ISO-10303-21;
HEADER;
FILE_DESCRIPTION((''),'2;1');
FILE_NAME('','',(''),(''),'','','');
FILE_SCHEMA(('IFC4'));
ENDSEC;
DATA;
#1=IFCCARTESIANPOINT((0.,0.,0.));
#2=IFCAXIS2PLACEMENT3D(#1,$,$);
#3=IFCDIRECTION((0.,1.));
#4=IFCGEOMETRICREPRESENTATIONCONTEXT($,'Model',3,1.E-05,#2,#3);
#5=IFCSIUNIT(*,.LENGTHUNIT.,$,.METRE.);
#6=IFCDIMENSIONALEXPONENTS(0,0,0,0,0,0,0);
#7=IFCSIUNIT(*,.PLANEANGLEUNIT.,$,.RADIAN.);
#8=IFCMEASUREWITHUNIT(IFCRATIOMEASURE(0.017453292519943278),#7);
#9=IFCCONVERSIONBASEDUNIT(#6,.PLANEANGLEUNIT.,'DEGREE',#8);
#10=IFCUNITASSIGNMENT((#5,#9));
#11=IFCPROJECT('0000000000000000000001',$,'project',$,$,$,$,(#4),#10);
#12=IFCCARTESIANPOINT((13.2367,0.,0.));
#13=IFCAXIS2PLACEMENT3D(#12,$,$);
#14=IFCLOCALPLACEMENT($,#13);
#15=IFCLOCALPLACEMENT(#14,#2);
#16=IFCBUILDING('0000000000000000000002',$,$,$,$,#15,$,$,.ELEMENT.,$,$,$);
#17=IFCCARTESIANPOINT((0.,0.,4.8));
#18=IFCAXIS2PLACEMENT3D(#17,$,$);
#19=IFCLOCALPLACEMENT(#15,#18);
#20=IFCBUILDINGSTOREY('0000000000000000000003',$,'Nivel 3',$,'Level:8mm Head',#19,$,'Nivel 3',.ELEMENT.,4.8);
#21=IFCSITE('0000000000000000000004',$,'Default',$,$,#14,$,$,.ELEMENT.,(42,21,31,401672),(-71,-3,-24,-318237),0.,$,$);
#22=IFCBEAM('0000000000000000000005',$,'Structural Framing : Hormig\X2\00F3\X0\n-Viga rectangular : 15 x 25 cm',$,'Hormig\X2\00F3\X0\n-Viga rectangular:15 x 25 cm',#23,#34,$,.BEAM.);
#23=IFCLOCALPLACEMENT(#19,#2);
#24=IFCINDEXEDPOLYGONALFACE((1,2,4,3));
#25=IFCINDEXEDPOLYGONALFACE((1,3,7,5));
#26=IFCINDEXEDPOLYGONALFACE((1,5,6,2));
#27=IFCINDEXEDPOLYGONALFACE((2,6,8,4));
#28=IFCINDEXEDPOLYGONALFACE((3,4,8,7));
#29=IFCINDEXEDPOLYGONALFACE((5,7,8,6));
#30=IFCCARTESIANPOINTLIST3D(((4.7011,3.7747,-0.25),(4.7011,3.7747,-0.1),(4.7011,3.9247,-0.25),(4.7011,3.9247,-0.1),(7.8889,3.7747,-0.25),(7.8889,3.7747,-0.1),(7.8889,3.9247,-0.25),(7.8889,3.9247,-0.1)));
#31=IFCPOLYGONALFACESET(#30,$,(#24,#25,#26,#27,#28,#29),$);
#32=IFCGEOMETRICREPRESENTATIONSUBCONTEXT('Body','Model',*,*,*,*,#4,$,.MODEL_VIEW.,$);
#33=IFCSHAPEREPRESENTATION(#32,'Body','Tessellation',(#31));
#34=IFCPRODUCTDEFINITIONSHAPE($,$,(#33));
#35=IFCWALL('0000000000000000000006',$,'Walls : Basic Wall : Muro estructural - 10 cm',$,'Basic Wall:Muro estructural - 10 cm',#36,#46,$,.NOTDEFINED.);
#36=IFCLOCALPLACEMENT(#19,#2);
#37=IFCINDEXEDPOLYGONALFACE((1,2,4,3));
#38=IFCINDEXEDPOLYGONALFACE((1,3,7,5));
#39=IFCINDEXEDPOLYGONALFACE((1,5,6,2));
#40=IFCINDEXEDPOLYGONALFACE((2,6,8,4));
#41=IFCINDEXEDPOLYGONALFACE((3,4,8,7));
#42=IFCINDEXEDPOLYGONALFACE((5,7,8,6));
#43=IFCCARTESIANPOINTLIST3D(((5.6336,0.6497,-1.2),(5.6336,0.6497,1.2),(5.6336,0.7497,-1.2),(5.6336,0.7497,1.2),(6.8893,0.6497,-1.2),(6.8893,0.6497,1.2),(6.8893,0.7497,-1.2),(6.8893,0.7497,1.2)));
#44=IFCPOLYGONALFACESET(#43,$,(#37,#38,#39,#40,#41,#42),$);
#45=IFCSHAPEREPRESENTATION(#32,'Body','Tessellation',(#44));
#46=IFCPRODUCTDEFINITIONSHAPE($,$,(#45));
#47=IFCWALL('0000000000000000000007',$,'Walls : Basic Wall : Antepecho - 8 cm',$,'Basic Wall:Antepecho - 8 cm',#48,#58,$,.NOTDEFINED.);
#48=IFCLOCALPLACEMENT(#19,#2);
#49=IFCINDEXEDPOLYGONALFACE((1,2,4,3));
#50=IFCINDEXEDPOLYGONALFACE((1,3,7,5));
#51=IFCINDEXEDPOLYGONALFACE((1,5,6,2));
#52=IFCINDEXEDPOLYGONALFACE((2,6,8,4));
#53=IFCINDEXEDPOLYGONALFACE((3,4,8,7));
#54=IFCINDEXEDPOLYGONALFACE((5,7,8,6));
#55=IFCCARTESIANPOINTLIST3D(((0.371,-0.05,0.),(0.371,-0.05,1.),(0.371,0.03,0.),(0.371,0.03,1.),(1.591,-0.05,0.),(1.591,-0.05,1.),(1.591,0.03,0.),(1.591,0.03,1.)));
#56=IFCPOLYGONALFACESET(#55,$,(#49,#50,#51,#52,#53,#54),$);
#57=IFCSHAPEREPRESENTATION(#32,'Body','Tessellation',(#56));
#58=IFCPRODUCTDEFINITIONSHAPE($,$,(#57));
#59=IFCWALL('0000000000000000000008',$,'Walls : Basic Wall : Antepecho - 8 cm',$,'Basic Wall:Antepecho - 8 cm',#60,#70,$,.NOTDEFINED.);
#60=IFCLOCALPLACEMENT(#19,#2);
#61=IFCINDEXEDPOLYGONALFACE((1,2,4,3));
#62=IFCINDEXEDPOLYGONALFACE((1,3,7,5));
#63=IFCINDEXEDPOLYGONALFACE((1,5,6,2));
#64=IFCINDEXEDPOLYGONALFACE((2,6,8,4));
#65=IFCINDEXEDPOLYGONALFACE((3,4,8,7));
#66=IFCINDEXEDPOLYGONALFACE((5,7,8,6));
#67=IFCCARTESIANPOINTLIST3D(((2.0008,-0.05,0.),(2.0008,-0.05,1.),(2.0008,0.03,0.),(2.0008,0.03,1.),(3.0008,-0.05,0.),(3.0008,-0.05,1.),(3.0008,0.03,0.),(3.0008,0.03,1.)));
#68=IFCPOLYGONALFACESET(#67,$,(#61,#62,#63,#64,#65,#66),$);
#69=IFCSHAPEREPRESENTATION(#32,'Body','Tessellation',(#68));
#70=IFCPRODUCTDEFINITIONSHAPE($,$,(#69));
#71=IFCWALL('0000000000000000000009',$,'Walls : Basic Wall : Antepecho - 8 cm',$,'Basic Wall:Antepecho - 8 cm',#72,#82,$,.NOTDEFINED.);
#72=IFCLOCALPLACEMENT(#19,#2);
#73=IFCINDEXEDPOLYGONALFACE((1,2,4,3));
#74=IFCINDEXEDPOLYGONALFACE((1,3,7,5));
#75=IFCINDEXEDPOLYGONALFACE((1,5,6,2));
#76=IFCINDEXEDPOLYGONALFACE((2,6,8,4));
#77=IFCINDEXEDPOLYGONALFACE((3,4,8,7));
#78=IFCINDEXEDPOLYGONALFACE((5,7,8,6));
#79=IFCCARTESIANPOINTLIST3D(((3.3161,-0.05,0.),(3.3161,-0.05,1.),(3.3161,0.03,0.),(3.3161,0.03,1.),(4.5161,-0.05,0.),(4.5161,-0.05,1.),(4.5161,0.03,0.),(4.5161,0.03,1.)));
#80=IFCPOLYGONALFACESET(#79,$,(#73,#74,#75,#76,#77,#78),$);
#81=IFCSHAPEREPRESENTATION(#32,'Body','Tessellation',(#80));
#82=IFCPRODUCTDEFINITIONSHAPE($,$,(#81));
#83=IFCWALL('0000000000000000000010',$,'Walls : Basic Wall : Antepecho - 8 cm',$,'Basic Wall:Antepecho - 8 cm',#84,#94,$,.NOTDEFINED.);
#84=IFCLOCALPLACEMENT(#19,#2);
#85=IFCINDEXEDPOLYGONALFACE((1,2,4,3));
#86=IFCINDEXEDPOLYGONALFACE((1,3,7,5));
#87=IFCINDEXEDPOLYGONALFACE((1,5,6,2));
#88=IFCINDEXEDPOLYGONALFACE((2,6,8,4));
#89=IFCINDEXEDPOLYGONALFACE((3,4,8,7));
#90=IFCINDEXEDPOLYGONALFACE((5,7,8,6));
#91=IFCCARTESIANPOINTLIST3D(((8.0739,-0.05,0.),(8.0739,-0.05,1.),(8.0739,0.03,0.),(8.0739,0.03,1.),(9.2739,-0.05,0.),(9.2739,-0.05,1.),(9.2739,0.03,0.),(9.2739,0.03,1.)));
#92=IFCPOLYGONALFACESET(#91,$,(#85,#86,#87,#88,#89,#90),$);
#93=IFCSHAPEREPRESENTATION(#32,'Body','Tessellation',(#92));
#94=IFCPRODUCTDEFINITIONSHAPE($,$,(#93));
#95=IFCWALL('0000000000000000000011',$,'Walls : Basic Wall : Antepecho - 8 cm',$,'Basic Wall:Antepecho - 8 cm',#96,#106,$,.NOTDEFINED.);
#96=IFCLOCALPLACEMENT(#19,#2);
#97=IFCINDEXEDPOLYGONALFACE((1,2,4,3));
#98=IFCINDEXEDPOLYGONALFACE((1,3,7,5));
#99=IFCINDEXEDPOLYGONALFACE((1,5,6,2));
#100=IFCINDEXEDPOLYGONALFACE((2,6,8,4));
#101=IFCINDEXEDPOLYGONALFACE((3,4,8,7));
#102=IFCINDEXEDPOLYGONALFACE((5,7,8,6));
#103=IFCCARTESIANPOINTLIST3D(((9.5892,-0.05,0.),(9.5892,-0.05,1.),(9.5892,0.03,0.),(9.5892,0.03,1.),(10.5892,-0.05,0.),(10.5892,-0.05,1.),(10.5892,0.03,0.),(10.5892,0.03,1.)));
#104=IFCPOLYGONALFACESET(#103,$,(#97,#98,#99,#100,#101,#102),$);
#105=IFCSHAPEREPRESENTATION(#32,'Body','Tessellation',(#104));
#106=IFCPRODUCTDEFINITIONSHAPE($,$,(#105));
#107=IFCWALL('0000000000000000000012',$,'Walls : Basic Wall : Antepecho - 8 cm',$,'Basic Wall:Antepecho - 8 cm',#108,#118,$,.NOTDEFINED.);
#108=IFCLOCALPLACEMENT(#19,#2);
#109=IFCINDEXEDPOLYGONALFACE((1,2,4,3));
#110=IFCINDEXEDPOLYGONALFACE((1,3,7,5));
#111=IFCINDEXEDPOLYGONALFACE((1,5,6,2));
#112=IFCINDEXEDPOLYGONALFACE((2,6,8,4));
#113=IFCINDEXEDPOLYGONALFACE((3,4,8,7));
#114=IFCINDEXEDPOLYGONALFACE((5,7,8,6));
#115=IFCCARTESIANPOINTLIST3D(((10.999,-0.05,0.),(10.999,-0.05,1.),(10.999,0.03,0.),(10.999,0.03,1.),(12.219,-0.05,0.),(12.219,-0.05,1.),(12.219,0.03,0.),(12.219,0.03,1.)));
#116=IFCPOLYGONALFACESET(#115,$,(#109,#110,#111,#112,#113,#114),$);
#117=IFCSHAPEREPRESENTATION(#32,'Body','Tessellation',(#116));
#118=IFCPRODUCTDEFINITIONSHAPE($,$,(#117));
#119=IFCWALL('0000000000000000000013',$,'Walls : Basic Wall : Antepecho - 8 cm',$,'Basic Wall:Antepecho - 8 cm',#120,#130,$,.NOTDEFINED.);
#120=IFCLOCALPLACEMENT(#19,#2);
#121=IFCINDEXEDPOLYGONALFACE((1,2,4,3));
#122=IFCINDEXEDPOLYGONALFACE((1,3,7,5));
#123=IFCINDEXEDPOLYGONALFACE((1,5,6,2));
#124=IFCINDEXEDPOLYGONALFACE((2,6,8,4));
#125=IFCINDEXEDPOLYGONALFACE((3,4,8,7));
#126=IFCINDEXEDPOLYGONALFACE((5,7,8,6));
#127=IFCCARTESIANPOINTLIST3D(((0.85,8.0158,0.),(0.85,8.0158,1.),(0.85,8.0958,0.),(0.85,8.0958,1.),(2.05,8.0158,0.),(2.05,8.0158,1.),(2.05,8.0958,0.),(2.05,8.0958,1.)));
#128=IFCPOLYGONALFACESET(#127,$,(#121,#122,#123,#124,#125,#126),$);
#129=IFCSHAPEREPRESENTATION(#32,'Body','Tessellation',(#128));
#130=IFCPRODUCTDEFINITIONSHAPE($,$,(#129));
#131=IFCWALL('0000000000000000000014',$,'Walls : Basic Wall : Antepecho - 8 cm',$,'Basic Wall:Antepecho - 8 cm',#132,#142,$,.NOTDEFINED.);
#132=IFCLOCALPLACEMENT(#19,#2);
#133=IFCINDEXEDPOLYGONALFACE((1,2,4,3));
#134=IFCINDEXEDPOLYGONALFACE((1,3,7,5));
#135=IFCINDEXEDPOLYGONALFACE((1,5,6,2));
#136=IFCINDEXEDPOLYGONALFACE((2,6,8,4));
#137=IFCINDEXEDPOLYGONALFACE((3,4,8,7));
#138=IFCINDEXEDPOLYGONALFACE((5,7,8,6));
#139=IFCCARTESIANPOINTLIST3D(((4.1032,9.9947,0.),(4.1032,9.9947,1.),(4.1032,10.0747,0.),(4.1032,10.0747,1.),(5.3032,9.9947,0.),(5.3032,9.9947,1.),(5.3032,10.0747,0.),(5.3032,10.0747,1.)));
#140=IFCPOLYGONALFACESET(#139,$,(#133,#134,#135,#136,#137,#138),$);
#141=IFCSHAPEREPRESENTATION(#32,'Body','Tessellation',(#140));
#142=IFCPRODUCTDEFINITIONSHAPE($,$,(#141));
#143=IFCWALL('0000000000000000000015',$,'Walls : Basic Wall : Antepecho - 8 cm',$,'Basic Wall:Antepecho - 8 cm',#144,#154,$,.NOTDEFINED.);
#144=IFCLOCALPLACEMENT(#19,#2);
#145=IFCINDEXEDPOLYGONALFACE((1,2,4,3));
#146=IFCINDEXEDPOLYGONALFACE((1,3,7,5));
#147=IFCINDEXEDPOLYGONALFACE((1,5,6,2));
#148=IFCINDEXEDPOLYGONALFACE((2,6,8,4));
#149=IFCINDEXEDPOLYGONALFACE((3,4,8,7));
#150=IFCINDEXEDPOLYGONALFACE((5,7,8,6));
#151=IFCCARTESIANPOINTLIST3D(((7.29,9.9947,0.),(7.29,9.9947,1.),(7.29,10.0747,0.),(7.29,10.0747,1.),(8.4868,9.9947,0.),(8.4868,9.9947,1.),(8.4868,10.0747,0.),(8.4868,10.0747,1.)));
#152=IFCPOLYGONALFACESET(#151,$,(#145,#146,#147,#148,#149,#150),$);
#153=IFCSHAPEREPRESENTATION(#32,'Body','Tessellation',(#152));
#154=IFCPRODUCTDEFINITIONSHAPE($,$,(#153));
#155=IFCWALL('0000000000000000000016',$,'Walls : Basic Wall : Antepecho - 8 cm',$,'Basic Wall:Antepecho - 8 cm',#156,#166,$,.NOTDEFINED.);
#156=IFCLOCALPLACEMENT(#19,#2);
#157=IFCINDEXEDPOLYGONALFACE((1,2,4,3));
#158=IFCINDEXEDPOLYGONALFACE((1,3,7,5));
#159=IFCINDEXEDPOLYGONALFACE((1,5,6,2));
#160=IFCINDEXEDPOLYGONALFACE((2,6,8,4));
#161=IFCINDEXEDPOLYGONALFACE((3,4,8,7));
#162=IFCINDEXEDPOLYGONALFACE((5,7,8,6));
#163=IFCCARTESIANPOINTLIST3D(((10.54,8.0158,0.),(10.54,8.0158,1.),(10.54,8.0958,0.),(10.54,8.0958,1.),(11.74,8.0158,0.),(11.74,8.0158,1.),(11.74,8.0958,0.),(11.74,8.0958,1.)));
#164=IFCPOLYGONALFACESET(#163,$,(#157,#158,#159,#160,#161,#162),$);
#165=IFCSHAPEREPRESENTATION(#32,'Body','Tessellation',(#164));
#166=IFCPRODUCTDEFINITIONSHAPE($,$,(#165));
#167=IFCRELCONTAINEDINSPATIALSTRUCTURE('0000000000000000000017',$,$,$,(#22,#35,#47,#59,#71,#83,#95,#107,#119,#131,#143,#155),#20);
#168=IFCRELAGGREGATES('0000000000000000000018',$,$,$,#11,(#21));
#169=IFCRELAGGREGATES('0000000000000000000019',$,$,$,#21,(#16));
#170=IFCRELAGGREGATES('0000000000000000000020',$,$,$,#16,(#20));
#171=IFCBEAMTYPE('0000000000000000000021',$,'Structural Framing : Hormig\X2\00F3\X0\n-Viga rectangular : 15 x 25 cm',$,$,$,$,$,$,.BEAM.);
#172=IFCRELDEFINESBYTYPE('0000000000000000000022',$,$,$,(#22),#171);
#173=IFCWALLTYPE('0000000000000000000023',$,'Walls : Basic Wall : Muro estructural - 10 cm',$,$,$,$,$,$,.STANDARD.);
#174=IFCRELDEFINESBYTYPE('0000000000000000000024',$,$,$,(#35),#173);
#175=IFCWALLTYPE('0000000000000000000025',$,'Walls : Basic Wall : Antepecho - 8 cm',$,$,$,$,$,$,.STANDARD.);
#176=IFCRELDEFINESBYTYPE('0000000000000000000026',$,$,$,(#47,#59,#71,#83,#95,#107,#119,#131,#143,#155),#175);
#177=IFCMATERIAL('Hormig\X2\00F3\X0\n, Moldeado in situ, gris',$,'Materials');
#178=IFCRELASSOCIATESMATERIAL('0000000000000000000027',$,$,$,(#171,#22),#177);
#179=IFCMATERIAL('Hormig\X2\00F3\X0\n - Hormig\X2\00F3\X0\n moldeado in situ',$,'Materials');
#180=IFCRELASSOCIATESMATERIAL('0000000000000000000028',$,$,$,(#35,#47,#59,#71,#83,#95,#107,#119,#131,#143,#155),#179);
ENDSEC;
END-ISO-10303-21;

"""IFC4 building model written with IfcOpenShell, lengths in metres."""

from ifc_helpers import new_model, entity, si_unit, converted_unit, direction, frame, origin, place, context, subcontext, project, spatial, indexed_curve, outline, extrude, source, transform, mapped, material, type_object, type_shapes, element, save


model = new_model("IFC4")

# Units and contexts
model_context = context("Model", 3, precision=1e-05, world=origin(), true_north=direction((0.0, 1.0)))
body_context = subcontext(model_context, "Body", "Model", "MODEL_VIEW")
ifc_project = project(units=[si_unit("LENGTHUNIT", "METRE"), converted_unit("PLANEANGLEUNIT", "DEGREE", entity("IfcRatioMeasure", 0.017453292519943278), si_unit("PLANEANGLEUNIT", "RADIAN"), dimensions=[0, 0, 0, 0, 0, 0, 0])], contexts=[model_context])

# Site, building, storey
site_placement = place(None, frame((13.2367, 0.0, 0.0)))
site = spatial("IfcSite", under=ifc_project, at=site_placement, Name="Default", CompositionType="ELEMENT", RefLatitude=(42, 21, 31, 401672), RefLongitude=(-71, -3, -24, -318237), RefElevation=0.0)
building_placement = place(site_placement, origin())
building = spatial("IfcBuilding", under=site, at=building_placement, CompositionType="ELEMENT")
storey_placement = place(building_placement, frame((0.0, 0.0, 4.8)))
storey = spatial("IfcBuildingStorey", under=building, at=storey_placement, Name="Nivel 3", ObjectType="Level:8mm Head", LongName="Nivel 3", CompositionType="ELEMENT", Elevation=4.8)

# Beam
ifc_material_1 = material(Name="Hormigón, Moldeado in situ, gris", Category="Materials")
beam_type_1 = type_object("IfcBeamType", Name="Structural Framing : Hormigón-Viga rectangular : 15 x 25 cm", PredefinedType="BEAM", material=ifc_material_1)
shared_shape_1 = source(origin(), body_context, "Body", "SweptSolid", [
    extrude(outline(indexed_curve([(-0.075, -0.075), (0.075, -0.075), (0.075, 0.075), (-0.075, 0.075), (-0.075, -0.075)], self_intersect=False)), frame((4.7011, 3.8497, 4.625), z_axis=(1.0, 0.0, 0.0), x_axis=(0.0, 0.0, -1.0)), (0.0, 0.0, 1.0), 3.1878),
])
type_shapes(beam_type_1, [shared_shape_1])
beam_1_placement = place(storey_placement, frame((0.0, 0.0, -4.8)))
element("IfcBeam", 1, at=beam_1_placement, inside=storey, type_object=beam_type_1, material=ifc_material_1, Name="Structural Framing : Hormigón-Viga rectangular : 15 x 25 cm", ObjectType="Hormigón-Viga rectangular:15 x 25 cm", PredefinedType="BEAM", context=body_context, shape_type="MappedRepresentation", body=[
    mapped(shared_shape_1, transform((0.0, 0.0, 0.0), scale=1.0)),
])

# Shared definitions
ifc_material_2 = material(Name="Hormigón - Hormigón moldeado in situ", Category="Materials")

# Walls
wall_type_1 = type_object("IfcWallType", Name="Walls : Basic Wall : Muro estructural - 10 cm", PredefinedType="STANDARD")
wall_1_placement = place(storey_placement, frame((5.6336, 0.6997, -1.2)))
element("IfcWall", 2, at=wall_1_placement, inside=storey, type_object=wall_type_1, material=ifc_material_2, Name="Walls : Basic Wall : Muro estructural - 10 cm", ObjectType="Basic Wall:Muro estructural - 10 cm", PredefinedType="NOTDEFINED", context=body_context, shape_type="SweptSolid", body=[
    extrude(outline(indexed_curve([(1.2557, 0.05), (0.0, 0.05), (0.0, -0.05), (1.2557, -0.05), (1.2557, 0.05)], self_intersect=False)), origin(), (0.0, 0.0, 1.0), 2.4),
])
wall_type_2 = type_object("IfcWallType", Name="Walls : Basic Wall : Antepecho - 8 cm", PredefinedType="STANDARD")
wall_2_placement = place(storey_placement, frame((0.371, -0.01, 0.0)))
element("IfcWall", 3, at=wall_2_placement, inside=storey, type_object=wall_type_2, material=ifc_material_2, Name="Walls : Basic Wall : Antepecho - 8 cm", ObjectType="Basic Wall:Antepecho - 8 cm", PredefinedType="NOTDEFINED", context=body_context, shape_type="SweptSolid", body=[
    extrude(outline(indexed_curve([(1.22, 0.04), (0.0, 0.04), (0.0, -0.04), (1.22, -0.04), (1.22, 0.04)], self_intersect=False)), origin(), (0.0, 0.0, 1.0), 1.0),
])
wall_3_placement = place(storey_placement, frame((2.0008, -0.01, 0.0)))
element("IfcWall", 4, at=wall_3_placement, inside=storey, type_object=wall_type_2, material=ifc_material_2, Name="Walls : Basic Wall : Antepecho - 8 cm", ObjectType="Basic Wall:Antepecho - 8 cm", PredefinedType="NOTDEFINED", context=body_context, shape_type="SweptSolid", body=[
    extrude(outline(indexed_curve([(1.0, 0.04), (0.0, 0.04), (0.0, -0.04), (1.0, -0.04), (1.0, 0.04)], self_intersect=False)), origin(), (0.0, 0.0, 1.0), 1.0),
])
wall_4_placement = place(storey_placement, frame((3.3161, -0.01, 0.0)))
element("IfcWall", 5, at=wall_4_placement, inside=storey, type_object=wall_type_2, material=ifc_material_2, Name="Walls : Basic Wall : Antepecho - 8 cm", ObjectType="Basic Wall:Antepecho - 8 cm", PredefinedType="NOTDEFINED", context=body_context, shape_type="SweptSolid", body=[
    extrude(outline(indexed_curve([(1.2, 0.04), (0.0, 0.04), (0.0, -0.04), (1.2, -0.04), (1.2, 0.04)], self_intersect=False)), origin(), (0.0, 0.0, 1.0), 1.0),
])
wall_5_placement = place(storey_placement, frame((8.0739, -0.01, 0.0)))
element("IfcWall", 6, at=wall_5_placement, inside=storey, type_object=wall_type_2, material=ifc_material_2, Name="Walls : Basic Wall : Antepecho - 8 cm", ObjectType="Basic Wall:Antepecho - 8 cm", PredefinedType="NOTDEFINED", context=body_context, shape_type="SweptSolid", body=[
    extrude(outline(indexed_curve([(1.2, 0.04), (0.0, 0.04), (0.0, -0.04), (1.2, -0.04), (1.2, 0.04)], self_intersect=False)), origin(), (0.0, 0.0, 1.0), 1.0),
])
wall_6_placement = place(storey_placement, frame((9.5892, -0.01, 0.0)))
element("IfcWall", 7, at=wall_6_placement, inside=storey, type_object=wall_type_2, material=ifc_material_2, Name="Walls : Basic Wall : Antepecho - 8 cm", ObjectType="Basic Wall:Antepecho - 8 cm", PredefinedType="NOTDEFINED", context=body_context, shape_type="SweptSolid", body=[
    extrude(outline(indexed_curve([(1.0, 0.04), (0.0, 0.04), (0.0, -0.04), (1.0, -0.04), (1.0, 0.04)], self_intersect=False)), origin(), (0.0, 0.0, 1.0), 1.0),
])
wall_7_placement = place(storey_placement, frame((10.999, -0.01, 0.0)))
element("IfcWall", 8, at=wall_7_placement, inside=storey, type_object=wall_type_2, material=ifc_material_2, Name="Walls : Basic Wall : Antepecho - 8 cm", ObjectType="Basic Wall:Antepecho - 8 cm", PredefinedType="NOTDEFINED", context=body_context, shape_type="SweptSolid", body=[
    extrude(outline(indexed_curve([(1.22, 0.04), (0.0, 0.04), (0.0, -0.04), (1.22, -0.04), (1.22, 0.04)], self_intersect=False)), origin(), (0.0, 0.0, 1.0), 1.0),
])
wall_8_placement = place(storey_placement, frame((2.05, 8.0558, 0.0), z_axis=(0.0, 0.0, 1.0), x_axis=(-1.0, 0.0, 0.0)))
element("IfcWall", 9, at=wall_8_placement, inside=storey, type_object=wall_type_2, material=ifc_material_2, Name="Walls : Basic Wall : Antepecho - 8 cm", ObjectType="Basic Wall:Antepecho - 8 cm", PredefinedType="NOTDEFINED", context=body_context, shape_type="SweptSolid", body=[
    extrude(outline(indexed_curve([(1.2, 0.04), (0.0, 0.04), (0.0, -0.04), (1.2, -0.04), (1.2, 0.04)], self_intersect=False)), origin(), (0.0, 0.0, 1.0), 1.0),
])
wall_9_placement = place(storey_placement, frame((5.3032, 10.0347, 0.0), z_axis=(0.0, 0.0, 1.0), x_axis=(-1.0, 0.0, 0.0)))
element("IfcWall", 10, at=wall_9_placement, inside=storey, type_object=wall_type_2, material=ifc_material_2, Name="Walls : Basic Wall : Antepecho - 8 cm", ObjectType="Basic Wall:Antepecho - 8 cm", PredefinedType="NOTDEFINED", context=body_context, shape_type="SweptSolid", body=[
    extrude(outline(indexed_curve([(1.2, 0.04), (0.0, 0.04), (0.0, -0.04), (1.2, -0.04), (1.2, 0.04)], self_intersect=False)), origin(), (0.0, 0.0, 1.0), 1.0),
])
wall_10_placement = place(storey_placement, frame((8.4868, 10.0347, 0.0), z_axis=(0.0, 0.0, 1.0), x_axis=(-1.0, 0.0, 0.0)))
element("IfcWall", 11, at=wall_10_placement, inside=storey, type_object=wall_type_2, material=ifc_material_2, Name="Walls : Basic Wall : Antepecho - 8 cm", ObjectType="Basic Wall:Antepecho - 8 cm", PredefinedType="NOTDEFINED", context=body_context, shape_type="SweptSolid", body=[
    extrude(outline(indexed_curve([(1.1968, 0.04), (0.0, 0.04), (0.0, -0.04), (1.1968, -0.04), (1.1968, 0.04)], self_intersect=False)), origin(), (0.0, 0.0, 1.0), 1.0),
])
wall_11_placement = place(storey_placement, frame((11.74, 8.0558, 0.0), z_axis=(0.0, 0.0, 1.0), x_axis=(-1.0, 0.0, 0.0)))
element("IfcWall", 12, at=wall_11_placement, inside=storey, type_object=wall_type_2, material=ifc_material_2, Name="Walls : Basic Wall : Antepecho - 8 cm", ObjectType="Basic Wall:Antepecho - 8 cm", PredefinedType="NOTDEFINED", context=body_context, shape_type="SweptSolid", body=[
    extrude(outline(indexed_curve([(1.2, 0.04), (0.0, 0.04), (0.0, -0.04), (1.2, -0.04), (1.2, 0.04)], self_intersect=False)), origin(), (0.0, 0.0, 1.0), 1.0),
])

save(model, "model.ifc")
